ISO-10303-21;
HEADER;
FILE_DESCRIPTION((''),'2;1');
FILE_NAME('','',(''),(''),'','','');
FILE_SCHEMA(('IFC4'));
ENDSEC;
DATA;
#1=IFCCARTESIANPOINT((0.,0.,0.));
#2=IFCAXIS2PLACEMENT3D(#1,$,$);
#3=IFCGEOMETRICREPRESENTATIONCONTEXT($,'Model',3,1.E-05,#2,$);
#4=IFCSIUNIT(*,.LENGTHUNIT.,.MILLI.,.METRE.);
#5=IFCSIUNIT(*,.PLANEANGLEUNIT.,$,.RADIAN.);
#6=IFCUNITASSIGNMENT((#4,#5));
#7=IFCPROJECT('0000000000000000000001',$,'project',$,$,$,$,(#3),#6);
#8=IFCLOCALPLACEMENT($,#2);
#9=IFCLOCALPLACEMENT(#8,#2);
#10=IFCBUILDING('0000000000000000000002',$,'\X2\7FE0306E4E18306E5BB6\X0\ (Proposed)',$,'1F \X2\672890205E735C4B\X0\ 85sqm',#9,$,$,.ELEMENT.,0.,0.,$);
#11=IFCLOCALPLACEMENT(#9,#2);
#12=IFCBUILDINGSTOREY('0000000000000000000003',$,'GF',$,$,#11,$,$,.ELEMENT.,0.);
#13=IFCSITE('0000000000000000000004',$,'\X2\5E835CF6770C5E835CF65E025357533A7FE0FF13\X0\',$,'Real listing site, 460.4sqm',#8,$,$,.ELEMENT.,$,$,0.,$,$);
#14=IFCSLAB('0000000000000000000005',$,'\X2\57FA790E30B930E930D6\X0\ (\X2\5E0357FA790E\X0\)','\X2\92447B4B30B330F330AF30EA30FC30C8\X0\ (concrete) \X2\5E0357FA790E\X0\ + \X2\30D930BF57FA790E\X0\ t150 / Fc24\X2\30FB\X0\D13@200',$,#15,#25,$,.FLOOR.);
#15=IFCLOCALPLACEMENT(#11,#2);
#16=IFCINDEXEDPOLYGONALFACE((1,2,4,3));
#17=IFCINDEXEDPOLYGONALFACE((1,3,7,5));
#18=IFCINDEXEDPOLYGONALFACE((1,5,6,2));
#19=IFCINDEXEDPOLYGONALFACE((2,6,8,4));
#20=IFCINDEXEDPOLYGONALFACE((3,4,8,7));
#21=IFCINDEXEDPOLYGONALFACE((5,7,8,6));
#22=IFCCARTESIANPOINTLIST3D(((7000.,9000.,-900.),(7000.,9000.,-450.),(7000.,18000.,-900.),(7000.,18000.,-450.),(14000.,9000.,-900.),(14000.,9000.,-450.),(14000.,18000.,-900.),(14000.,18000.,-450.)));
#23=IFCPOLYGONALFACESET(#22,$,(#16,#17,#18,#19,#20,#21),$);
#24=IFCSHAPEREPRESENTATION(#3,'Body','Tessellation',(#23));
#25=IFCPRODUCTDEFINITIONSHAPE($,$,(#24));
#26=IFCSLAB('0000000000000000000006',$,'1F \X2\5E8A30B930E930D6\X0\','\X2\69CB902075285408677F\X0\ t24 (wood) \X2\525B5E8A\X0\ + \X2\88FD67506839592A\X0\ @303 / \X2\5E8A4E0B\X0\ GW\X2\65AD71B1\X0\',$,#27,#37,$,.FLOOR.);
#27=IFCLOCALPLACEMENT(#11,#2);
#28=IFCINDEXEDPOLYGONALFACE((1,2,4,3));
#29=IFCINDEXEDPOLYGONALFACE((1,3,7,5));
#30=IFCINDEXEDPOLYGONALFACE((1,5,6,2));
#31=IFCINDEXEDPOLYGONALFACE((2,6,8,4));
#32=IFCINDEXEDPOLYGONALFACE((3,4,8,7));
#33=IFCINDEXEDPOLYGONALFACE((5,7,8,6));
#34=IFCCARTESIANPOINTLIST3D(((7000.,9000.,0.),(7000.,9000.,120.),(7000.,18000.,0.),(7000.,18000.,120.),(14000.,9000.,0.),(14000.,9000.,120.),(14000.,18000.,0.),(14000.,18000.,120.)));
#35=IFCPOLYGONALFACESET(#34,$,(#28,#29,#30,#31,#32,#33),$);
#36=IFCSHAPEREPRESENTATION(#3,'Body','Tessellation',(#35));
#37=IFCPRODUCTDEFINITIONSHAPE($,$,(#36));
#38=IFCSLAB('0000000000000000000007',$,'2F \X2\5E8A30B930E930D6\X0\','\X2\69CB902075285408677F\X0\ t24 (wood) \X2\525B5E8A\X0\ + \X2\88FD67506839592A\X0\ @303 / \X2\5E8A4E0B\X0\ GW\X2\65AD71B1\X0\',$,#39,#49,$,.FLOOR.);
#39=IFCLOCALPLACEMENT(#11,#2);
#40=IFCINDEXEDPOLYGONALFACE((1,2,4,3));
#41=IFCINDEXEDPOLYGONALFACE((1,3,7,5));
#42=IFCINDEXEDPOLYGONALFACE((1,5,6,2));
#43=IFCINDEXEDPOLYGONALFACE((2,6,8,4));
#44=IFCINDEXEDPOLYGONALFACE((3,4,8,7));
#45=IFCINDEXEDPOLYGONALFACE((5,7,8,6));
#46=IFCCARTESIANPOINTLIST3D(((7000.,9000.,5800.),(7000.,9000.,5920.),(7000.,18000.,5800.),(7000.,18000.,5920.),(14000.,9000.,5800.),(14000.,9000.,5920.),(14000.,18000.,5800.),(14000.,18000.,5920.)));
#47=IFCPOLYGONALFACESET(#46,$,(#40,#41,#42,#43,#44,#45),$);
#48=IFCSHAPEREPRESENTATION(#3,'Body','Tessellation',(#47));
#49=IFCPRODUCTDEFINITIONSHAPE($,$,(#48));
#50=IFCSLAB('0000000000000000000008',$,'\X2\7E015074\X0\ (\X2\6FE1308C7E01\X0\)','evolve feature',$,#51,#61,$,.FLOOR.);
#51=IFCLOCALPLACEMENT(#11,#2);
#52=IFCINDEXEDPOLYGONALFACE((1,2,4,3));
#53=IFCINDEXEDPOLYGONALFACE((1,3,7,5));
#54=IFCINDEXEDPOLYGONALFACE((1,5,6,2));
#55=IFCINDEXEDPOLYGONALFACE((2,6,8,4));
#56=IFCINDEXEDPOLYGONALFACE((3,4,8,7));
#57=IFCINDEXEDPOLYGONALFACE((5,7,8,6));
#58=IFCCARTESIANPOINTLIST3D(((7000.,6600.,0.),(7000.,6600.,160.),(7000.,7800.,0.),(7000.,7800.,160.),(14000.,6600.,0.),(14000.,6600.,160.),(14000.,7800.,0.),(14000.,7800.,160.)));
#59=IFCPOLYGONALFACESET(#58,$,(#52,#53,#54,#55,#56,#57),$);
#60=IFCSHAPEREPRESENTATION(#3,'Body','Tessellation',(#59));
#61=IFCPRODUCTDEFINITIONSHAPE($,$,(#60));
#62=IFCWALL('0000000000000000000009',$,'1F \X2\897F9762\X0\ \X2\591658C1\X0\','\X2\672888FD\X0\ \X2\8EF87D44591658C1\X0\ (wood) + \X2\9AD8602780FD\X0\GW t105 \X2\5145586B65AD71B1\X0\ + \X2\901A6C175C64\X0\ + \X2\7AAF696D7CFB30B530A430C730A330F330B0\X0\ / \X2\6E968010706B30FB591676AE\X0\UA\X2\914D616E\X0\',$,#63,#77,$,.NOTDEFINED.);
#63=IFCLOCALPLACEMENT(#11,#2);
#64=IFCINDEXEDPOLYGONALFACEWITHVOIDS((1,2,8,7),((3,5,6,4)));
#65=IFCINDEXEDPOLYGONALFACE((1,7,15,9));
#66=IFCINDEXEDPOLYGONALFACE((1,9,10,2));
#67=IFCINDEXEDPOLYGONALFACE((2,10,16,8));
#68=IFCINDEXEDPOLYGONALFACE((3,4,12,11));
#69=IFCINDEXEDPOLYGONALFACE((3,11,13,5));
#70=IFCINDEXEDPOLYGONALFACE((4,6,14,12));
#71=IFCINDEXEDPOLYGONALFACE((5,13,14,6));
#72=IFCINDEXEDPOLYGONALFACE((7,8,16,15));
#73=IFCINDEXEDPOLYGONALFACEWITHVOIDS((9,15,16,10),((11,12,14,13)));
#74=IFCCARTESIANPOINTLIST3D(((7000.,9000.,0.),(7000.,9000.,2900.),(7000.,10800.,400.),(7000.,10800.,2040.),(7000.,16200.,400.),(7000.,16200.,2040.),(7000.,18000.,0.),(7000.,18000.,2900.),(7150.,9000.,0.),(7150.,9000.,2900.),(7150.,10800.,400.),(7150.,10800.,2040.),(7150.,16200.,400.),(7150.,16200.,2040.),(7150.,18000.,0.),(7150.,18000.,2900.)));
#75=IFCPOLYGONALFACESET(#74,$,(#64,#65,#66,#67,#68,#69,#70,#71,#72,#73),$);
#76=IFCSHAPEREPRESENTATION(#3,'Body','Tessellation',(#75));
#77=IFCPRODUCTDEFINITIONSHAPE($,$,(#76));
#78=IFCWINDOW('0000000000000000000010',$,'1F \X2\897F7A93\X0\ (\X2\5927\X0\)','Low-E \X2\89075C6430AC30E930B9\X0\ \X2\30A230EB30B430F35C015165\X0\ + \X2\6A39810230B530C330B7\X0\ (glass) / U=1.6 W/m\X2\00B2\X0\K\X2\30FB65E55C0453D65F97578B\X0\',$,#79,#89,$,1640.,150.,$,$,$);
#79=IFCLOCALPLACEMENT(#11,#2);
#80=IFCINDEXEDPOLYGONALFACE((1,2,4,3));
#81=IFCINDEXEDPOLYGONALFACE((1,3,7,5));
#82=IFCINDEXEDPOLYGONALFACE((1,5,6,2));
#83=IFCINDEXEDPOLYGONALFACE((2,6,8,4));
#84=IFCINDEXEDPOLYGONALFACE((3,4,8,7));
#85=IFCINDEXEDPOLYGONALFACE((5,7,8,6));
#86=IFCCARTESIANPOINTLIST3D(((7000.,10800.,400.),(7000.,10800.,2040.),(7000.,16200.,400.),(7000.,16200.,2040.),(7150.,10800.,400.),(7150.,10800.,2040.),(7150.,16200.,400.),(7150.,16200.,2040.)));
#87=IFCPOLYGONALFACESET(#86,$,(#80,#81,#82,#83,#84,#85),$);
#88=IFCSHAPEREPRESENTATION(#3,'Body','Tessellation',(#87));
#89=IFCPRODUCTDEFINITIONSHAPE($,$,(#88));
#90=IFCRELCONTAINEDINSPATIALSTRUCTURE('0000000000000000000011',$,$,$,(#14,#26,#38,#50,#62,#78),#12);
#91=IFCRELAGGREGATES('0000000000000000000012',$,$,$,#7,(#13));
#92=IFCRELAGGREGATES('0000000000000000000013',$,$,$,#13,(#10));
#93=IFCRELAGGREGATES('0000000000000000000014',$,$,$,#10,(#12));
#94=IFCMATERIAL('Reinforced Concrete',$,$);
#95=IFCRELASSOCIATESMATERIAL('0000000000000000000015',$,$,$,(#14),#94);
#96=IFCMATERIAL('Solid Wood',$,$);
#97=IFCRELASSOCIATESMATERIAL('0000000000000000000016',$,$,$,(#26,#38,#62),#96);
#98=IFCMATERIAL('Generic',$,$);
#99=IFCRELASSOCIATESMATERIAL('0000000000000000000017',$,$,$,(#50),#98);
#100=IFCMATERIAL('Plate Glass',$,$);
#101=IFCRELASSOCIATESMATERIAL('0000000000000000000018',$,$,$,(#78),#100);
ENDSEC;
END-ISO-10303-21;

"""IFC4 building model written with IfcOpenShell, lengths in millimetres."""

from ifc_helpers import new_model, si_unit, frame, frame_2d, origin, place, context, project, spatial, rectangle, extrude, material, element, fill, save


model = new_model("IFC4")

# Units and contexts
model_context = context("Model", 3, precision=1e-05, world=origin())
ifc_project = project(units=[si_unit("LENGTHUNIT", "METRE", prefix="MILLI"), si_unit("PLANEANGLEUNIT", "RADIAN")], contexts=[model_context])

# Site, building, storey
site_placement = place(None, origin())
site = spatial("IfcSite", under=ifc_project, at=site_placement, Name="広島県広島市南区翠３", ObjectType="Real listing site, 460.4sqm", CompositionType="ELEMENT", RefElevation=0.0)
building_placement = place(site_placement, origin())
building = spatial("IfcBuilding", under=site, at=building_placement, Name="翠の丘の家 (Proposed)", ObjectType="1F 木造平屋 85sqm", CompositionType="ELEMENT", ElevationOfRefHeight=0.0, ElevationOfTerrain=0.0)
storey_placement = place(building_placement, origin())
storey = spatial("IfcBuildingStorey", under=building, at=storey_placement, Name="GF", CompositionType="ELEMENT", Elevation=0.0)

# Slabs
ifc_material_1 = material(Name="Reinforced Concrete")
slab_1_placement = place(storey_placement, frame((3500.0, 4500.0, -450.0)))
element("IfcSlab", 1, at=slab_1_placement, inside=storey, material=ifc_material_1, Name="基礎スラブ (布基礎)", Description="鉄筋コンクリート (concrete) 布基礎 + ベタ基礎 t150 / Fc24・D13@200", PredefinedType="FLOOR", context=model_context, shape_type="SweptSolid", body=[
    extrude(rectangle(XDim=7000.0, YDim=9000.0, at=frame_2d((3500.0, 4500.0))), frame((3500.0, 4500.0, -450.0)), (0.0, 0.0, 1.0), 450.0),
])
ifc_material_2 = material(Name="Solid Wood")
slab_2_placement = place(storey_placement, frame((3500.0, 4500.0, 0.0)))
element("IfcSlab", 2, at=slab_2_placement, inside=storey, material=ifc_material_2, Name="1F 床スラブ", Description="構造用合板 t24 (wood) 剛床 + 製材根太 @303 / 床下 GW断熱", PredefinedType="FLOOR", context=model_context, shape_type="SweptSolid", body=[
    extrude(rectangle(XDim=7000.0, YDim=9000.0, at=frame_2d((3500.0, 4500.0))), frame((3500.0, 4500.0, 0.0)), (0.0, 0.0, 1.0), 120.0),
])
slab_3_placement = place(storey_placement, frame((3500.0, 4500.0, 2900.0)))
element("IfcSlab", 3, at=slab_3_placement, inside=storey, material=ifc_material_2, Name="2F 床スラブ", Description="構造用合板 t24 (wood) 剛床 + 製材根太 @303 / 床下 GW断熱", PredefinedType="FLOOR", context=model_context, shape_type="SweptSolid", body=[
    extrude(rectangle(XDim=7000.0, YDim=9000.0, at=frame_2d((3500.0, 4500.0))), frame((3500.0, 4500.0, 2900.0)), (0.0, 0.0, 1.0), 120.0),
])
ifc_material_3 = material(Name="Generic")
slab_4_placement = place(storey_placement, frame((3500.0, 3300.0, 0.0)))
element("IfcSlab", 4, at=slab_4_placement, inside=storey, material=ifc_material_3, Name="縁側 (濡れ縁)", Description="evolve feature", PredefinedType="FLOOR", context=model_context, shape_type="SweptSolid", body=[
    extrude(rectangle(XDim=7000.0, YDim=1200.0, at=frame_2d((3500.0, 600.0))), frame((3500.0, 3300.0, 0.0)), (0.0, 0.0, 1.0), 160.0),
])

# Shared definitions
ifc_material_4 = material(Name="Plate Glass")

# Wall, opening, window
wall_1_placement = place(storey_placement, frame((3500.0, 4500.0, 0.0)))
wall_1 = element("IfcWall", 5, at=wall_1_placement, inside=storey, material=ifc_material_2, Name="1F 西面 外壁", Description="木製 軸組外壁 (wood) + 高性能GW t105 充填断熱 + 通気層 + 窯業系サイディング / 準耐火・外皮UA配慮", PredefinedType="NOTDEFINED", context=model_context, shape_type="SweptSolid", body=[
    extrude(rectangle(XDim=150.0, YDim=9000.0, at=frame_2d((75.0, 4500.0))), frame((3500.0, 4500.0, 0.0)), (0.0, 0.0, 1.0), 2900.0),
])
opening_1_placement = place(storey_placement, frame((3500.0, 5400.0, 200.0)))
opening_1 = element("IfcOpeningElement", 6, at=opening_1_placement, cuts=wall_1, PredefinedType="NOTDEFINED", context=model_context, shape_type="SweptSolid", body=[
    extrude(rectangle(XDim=150.0, YDim=5400.0, at=frame_2d((75.0, 2700.0))), frame((3500.0, 5400.0, 200.0)), (0.0, 0.0, 1.0), 1640.0),
])
window_1_placement = place(storey_placement, frame((3500.0, 5400.0, 200.0)))
window_1 = element("IfcWindow", 7, at=window_1_placement, inside=storey, material=ifc_material_4, Name="1F 西窓 (大)", Description="Low-E 複層ガラス アルゴン封入 + 樹脂サッシ (glass) / U=1.6 W/m²K・日射取得型", OverallHeight=1640.0, OverallWidth=150.0, context=model_context, shape_type="SweptSolid", body=[
    extrude(rectangle(XDim=150.0, YDim=5400.0, at=frame_2d((75.0, 2700.0))), frame((3500.0, 5400.0, 200.0)), (0.0, 0.0, 1.0), 1640.0),
])
fill(opening_1, window_1)

save(model, "model.ifc")
